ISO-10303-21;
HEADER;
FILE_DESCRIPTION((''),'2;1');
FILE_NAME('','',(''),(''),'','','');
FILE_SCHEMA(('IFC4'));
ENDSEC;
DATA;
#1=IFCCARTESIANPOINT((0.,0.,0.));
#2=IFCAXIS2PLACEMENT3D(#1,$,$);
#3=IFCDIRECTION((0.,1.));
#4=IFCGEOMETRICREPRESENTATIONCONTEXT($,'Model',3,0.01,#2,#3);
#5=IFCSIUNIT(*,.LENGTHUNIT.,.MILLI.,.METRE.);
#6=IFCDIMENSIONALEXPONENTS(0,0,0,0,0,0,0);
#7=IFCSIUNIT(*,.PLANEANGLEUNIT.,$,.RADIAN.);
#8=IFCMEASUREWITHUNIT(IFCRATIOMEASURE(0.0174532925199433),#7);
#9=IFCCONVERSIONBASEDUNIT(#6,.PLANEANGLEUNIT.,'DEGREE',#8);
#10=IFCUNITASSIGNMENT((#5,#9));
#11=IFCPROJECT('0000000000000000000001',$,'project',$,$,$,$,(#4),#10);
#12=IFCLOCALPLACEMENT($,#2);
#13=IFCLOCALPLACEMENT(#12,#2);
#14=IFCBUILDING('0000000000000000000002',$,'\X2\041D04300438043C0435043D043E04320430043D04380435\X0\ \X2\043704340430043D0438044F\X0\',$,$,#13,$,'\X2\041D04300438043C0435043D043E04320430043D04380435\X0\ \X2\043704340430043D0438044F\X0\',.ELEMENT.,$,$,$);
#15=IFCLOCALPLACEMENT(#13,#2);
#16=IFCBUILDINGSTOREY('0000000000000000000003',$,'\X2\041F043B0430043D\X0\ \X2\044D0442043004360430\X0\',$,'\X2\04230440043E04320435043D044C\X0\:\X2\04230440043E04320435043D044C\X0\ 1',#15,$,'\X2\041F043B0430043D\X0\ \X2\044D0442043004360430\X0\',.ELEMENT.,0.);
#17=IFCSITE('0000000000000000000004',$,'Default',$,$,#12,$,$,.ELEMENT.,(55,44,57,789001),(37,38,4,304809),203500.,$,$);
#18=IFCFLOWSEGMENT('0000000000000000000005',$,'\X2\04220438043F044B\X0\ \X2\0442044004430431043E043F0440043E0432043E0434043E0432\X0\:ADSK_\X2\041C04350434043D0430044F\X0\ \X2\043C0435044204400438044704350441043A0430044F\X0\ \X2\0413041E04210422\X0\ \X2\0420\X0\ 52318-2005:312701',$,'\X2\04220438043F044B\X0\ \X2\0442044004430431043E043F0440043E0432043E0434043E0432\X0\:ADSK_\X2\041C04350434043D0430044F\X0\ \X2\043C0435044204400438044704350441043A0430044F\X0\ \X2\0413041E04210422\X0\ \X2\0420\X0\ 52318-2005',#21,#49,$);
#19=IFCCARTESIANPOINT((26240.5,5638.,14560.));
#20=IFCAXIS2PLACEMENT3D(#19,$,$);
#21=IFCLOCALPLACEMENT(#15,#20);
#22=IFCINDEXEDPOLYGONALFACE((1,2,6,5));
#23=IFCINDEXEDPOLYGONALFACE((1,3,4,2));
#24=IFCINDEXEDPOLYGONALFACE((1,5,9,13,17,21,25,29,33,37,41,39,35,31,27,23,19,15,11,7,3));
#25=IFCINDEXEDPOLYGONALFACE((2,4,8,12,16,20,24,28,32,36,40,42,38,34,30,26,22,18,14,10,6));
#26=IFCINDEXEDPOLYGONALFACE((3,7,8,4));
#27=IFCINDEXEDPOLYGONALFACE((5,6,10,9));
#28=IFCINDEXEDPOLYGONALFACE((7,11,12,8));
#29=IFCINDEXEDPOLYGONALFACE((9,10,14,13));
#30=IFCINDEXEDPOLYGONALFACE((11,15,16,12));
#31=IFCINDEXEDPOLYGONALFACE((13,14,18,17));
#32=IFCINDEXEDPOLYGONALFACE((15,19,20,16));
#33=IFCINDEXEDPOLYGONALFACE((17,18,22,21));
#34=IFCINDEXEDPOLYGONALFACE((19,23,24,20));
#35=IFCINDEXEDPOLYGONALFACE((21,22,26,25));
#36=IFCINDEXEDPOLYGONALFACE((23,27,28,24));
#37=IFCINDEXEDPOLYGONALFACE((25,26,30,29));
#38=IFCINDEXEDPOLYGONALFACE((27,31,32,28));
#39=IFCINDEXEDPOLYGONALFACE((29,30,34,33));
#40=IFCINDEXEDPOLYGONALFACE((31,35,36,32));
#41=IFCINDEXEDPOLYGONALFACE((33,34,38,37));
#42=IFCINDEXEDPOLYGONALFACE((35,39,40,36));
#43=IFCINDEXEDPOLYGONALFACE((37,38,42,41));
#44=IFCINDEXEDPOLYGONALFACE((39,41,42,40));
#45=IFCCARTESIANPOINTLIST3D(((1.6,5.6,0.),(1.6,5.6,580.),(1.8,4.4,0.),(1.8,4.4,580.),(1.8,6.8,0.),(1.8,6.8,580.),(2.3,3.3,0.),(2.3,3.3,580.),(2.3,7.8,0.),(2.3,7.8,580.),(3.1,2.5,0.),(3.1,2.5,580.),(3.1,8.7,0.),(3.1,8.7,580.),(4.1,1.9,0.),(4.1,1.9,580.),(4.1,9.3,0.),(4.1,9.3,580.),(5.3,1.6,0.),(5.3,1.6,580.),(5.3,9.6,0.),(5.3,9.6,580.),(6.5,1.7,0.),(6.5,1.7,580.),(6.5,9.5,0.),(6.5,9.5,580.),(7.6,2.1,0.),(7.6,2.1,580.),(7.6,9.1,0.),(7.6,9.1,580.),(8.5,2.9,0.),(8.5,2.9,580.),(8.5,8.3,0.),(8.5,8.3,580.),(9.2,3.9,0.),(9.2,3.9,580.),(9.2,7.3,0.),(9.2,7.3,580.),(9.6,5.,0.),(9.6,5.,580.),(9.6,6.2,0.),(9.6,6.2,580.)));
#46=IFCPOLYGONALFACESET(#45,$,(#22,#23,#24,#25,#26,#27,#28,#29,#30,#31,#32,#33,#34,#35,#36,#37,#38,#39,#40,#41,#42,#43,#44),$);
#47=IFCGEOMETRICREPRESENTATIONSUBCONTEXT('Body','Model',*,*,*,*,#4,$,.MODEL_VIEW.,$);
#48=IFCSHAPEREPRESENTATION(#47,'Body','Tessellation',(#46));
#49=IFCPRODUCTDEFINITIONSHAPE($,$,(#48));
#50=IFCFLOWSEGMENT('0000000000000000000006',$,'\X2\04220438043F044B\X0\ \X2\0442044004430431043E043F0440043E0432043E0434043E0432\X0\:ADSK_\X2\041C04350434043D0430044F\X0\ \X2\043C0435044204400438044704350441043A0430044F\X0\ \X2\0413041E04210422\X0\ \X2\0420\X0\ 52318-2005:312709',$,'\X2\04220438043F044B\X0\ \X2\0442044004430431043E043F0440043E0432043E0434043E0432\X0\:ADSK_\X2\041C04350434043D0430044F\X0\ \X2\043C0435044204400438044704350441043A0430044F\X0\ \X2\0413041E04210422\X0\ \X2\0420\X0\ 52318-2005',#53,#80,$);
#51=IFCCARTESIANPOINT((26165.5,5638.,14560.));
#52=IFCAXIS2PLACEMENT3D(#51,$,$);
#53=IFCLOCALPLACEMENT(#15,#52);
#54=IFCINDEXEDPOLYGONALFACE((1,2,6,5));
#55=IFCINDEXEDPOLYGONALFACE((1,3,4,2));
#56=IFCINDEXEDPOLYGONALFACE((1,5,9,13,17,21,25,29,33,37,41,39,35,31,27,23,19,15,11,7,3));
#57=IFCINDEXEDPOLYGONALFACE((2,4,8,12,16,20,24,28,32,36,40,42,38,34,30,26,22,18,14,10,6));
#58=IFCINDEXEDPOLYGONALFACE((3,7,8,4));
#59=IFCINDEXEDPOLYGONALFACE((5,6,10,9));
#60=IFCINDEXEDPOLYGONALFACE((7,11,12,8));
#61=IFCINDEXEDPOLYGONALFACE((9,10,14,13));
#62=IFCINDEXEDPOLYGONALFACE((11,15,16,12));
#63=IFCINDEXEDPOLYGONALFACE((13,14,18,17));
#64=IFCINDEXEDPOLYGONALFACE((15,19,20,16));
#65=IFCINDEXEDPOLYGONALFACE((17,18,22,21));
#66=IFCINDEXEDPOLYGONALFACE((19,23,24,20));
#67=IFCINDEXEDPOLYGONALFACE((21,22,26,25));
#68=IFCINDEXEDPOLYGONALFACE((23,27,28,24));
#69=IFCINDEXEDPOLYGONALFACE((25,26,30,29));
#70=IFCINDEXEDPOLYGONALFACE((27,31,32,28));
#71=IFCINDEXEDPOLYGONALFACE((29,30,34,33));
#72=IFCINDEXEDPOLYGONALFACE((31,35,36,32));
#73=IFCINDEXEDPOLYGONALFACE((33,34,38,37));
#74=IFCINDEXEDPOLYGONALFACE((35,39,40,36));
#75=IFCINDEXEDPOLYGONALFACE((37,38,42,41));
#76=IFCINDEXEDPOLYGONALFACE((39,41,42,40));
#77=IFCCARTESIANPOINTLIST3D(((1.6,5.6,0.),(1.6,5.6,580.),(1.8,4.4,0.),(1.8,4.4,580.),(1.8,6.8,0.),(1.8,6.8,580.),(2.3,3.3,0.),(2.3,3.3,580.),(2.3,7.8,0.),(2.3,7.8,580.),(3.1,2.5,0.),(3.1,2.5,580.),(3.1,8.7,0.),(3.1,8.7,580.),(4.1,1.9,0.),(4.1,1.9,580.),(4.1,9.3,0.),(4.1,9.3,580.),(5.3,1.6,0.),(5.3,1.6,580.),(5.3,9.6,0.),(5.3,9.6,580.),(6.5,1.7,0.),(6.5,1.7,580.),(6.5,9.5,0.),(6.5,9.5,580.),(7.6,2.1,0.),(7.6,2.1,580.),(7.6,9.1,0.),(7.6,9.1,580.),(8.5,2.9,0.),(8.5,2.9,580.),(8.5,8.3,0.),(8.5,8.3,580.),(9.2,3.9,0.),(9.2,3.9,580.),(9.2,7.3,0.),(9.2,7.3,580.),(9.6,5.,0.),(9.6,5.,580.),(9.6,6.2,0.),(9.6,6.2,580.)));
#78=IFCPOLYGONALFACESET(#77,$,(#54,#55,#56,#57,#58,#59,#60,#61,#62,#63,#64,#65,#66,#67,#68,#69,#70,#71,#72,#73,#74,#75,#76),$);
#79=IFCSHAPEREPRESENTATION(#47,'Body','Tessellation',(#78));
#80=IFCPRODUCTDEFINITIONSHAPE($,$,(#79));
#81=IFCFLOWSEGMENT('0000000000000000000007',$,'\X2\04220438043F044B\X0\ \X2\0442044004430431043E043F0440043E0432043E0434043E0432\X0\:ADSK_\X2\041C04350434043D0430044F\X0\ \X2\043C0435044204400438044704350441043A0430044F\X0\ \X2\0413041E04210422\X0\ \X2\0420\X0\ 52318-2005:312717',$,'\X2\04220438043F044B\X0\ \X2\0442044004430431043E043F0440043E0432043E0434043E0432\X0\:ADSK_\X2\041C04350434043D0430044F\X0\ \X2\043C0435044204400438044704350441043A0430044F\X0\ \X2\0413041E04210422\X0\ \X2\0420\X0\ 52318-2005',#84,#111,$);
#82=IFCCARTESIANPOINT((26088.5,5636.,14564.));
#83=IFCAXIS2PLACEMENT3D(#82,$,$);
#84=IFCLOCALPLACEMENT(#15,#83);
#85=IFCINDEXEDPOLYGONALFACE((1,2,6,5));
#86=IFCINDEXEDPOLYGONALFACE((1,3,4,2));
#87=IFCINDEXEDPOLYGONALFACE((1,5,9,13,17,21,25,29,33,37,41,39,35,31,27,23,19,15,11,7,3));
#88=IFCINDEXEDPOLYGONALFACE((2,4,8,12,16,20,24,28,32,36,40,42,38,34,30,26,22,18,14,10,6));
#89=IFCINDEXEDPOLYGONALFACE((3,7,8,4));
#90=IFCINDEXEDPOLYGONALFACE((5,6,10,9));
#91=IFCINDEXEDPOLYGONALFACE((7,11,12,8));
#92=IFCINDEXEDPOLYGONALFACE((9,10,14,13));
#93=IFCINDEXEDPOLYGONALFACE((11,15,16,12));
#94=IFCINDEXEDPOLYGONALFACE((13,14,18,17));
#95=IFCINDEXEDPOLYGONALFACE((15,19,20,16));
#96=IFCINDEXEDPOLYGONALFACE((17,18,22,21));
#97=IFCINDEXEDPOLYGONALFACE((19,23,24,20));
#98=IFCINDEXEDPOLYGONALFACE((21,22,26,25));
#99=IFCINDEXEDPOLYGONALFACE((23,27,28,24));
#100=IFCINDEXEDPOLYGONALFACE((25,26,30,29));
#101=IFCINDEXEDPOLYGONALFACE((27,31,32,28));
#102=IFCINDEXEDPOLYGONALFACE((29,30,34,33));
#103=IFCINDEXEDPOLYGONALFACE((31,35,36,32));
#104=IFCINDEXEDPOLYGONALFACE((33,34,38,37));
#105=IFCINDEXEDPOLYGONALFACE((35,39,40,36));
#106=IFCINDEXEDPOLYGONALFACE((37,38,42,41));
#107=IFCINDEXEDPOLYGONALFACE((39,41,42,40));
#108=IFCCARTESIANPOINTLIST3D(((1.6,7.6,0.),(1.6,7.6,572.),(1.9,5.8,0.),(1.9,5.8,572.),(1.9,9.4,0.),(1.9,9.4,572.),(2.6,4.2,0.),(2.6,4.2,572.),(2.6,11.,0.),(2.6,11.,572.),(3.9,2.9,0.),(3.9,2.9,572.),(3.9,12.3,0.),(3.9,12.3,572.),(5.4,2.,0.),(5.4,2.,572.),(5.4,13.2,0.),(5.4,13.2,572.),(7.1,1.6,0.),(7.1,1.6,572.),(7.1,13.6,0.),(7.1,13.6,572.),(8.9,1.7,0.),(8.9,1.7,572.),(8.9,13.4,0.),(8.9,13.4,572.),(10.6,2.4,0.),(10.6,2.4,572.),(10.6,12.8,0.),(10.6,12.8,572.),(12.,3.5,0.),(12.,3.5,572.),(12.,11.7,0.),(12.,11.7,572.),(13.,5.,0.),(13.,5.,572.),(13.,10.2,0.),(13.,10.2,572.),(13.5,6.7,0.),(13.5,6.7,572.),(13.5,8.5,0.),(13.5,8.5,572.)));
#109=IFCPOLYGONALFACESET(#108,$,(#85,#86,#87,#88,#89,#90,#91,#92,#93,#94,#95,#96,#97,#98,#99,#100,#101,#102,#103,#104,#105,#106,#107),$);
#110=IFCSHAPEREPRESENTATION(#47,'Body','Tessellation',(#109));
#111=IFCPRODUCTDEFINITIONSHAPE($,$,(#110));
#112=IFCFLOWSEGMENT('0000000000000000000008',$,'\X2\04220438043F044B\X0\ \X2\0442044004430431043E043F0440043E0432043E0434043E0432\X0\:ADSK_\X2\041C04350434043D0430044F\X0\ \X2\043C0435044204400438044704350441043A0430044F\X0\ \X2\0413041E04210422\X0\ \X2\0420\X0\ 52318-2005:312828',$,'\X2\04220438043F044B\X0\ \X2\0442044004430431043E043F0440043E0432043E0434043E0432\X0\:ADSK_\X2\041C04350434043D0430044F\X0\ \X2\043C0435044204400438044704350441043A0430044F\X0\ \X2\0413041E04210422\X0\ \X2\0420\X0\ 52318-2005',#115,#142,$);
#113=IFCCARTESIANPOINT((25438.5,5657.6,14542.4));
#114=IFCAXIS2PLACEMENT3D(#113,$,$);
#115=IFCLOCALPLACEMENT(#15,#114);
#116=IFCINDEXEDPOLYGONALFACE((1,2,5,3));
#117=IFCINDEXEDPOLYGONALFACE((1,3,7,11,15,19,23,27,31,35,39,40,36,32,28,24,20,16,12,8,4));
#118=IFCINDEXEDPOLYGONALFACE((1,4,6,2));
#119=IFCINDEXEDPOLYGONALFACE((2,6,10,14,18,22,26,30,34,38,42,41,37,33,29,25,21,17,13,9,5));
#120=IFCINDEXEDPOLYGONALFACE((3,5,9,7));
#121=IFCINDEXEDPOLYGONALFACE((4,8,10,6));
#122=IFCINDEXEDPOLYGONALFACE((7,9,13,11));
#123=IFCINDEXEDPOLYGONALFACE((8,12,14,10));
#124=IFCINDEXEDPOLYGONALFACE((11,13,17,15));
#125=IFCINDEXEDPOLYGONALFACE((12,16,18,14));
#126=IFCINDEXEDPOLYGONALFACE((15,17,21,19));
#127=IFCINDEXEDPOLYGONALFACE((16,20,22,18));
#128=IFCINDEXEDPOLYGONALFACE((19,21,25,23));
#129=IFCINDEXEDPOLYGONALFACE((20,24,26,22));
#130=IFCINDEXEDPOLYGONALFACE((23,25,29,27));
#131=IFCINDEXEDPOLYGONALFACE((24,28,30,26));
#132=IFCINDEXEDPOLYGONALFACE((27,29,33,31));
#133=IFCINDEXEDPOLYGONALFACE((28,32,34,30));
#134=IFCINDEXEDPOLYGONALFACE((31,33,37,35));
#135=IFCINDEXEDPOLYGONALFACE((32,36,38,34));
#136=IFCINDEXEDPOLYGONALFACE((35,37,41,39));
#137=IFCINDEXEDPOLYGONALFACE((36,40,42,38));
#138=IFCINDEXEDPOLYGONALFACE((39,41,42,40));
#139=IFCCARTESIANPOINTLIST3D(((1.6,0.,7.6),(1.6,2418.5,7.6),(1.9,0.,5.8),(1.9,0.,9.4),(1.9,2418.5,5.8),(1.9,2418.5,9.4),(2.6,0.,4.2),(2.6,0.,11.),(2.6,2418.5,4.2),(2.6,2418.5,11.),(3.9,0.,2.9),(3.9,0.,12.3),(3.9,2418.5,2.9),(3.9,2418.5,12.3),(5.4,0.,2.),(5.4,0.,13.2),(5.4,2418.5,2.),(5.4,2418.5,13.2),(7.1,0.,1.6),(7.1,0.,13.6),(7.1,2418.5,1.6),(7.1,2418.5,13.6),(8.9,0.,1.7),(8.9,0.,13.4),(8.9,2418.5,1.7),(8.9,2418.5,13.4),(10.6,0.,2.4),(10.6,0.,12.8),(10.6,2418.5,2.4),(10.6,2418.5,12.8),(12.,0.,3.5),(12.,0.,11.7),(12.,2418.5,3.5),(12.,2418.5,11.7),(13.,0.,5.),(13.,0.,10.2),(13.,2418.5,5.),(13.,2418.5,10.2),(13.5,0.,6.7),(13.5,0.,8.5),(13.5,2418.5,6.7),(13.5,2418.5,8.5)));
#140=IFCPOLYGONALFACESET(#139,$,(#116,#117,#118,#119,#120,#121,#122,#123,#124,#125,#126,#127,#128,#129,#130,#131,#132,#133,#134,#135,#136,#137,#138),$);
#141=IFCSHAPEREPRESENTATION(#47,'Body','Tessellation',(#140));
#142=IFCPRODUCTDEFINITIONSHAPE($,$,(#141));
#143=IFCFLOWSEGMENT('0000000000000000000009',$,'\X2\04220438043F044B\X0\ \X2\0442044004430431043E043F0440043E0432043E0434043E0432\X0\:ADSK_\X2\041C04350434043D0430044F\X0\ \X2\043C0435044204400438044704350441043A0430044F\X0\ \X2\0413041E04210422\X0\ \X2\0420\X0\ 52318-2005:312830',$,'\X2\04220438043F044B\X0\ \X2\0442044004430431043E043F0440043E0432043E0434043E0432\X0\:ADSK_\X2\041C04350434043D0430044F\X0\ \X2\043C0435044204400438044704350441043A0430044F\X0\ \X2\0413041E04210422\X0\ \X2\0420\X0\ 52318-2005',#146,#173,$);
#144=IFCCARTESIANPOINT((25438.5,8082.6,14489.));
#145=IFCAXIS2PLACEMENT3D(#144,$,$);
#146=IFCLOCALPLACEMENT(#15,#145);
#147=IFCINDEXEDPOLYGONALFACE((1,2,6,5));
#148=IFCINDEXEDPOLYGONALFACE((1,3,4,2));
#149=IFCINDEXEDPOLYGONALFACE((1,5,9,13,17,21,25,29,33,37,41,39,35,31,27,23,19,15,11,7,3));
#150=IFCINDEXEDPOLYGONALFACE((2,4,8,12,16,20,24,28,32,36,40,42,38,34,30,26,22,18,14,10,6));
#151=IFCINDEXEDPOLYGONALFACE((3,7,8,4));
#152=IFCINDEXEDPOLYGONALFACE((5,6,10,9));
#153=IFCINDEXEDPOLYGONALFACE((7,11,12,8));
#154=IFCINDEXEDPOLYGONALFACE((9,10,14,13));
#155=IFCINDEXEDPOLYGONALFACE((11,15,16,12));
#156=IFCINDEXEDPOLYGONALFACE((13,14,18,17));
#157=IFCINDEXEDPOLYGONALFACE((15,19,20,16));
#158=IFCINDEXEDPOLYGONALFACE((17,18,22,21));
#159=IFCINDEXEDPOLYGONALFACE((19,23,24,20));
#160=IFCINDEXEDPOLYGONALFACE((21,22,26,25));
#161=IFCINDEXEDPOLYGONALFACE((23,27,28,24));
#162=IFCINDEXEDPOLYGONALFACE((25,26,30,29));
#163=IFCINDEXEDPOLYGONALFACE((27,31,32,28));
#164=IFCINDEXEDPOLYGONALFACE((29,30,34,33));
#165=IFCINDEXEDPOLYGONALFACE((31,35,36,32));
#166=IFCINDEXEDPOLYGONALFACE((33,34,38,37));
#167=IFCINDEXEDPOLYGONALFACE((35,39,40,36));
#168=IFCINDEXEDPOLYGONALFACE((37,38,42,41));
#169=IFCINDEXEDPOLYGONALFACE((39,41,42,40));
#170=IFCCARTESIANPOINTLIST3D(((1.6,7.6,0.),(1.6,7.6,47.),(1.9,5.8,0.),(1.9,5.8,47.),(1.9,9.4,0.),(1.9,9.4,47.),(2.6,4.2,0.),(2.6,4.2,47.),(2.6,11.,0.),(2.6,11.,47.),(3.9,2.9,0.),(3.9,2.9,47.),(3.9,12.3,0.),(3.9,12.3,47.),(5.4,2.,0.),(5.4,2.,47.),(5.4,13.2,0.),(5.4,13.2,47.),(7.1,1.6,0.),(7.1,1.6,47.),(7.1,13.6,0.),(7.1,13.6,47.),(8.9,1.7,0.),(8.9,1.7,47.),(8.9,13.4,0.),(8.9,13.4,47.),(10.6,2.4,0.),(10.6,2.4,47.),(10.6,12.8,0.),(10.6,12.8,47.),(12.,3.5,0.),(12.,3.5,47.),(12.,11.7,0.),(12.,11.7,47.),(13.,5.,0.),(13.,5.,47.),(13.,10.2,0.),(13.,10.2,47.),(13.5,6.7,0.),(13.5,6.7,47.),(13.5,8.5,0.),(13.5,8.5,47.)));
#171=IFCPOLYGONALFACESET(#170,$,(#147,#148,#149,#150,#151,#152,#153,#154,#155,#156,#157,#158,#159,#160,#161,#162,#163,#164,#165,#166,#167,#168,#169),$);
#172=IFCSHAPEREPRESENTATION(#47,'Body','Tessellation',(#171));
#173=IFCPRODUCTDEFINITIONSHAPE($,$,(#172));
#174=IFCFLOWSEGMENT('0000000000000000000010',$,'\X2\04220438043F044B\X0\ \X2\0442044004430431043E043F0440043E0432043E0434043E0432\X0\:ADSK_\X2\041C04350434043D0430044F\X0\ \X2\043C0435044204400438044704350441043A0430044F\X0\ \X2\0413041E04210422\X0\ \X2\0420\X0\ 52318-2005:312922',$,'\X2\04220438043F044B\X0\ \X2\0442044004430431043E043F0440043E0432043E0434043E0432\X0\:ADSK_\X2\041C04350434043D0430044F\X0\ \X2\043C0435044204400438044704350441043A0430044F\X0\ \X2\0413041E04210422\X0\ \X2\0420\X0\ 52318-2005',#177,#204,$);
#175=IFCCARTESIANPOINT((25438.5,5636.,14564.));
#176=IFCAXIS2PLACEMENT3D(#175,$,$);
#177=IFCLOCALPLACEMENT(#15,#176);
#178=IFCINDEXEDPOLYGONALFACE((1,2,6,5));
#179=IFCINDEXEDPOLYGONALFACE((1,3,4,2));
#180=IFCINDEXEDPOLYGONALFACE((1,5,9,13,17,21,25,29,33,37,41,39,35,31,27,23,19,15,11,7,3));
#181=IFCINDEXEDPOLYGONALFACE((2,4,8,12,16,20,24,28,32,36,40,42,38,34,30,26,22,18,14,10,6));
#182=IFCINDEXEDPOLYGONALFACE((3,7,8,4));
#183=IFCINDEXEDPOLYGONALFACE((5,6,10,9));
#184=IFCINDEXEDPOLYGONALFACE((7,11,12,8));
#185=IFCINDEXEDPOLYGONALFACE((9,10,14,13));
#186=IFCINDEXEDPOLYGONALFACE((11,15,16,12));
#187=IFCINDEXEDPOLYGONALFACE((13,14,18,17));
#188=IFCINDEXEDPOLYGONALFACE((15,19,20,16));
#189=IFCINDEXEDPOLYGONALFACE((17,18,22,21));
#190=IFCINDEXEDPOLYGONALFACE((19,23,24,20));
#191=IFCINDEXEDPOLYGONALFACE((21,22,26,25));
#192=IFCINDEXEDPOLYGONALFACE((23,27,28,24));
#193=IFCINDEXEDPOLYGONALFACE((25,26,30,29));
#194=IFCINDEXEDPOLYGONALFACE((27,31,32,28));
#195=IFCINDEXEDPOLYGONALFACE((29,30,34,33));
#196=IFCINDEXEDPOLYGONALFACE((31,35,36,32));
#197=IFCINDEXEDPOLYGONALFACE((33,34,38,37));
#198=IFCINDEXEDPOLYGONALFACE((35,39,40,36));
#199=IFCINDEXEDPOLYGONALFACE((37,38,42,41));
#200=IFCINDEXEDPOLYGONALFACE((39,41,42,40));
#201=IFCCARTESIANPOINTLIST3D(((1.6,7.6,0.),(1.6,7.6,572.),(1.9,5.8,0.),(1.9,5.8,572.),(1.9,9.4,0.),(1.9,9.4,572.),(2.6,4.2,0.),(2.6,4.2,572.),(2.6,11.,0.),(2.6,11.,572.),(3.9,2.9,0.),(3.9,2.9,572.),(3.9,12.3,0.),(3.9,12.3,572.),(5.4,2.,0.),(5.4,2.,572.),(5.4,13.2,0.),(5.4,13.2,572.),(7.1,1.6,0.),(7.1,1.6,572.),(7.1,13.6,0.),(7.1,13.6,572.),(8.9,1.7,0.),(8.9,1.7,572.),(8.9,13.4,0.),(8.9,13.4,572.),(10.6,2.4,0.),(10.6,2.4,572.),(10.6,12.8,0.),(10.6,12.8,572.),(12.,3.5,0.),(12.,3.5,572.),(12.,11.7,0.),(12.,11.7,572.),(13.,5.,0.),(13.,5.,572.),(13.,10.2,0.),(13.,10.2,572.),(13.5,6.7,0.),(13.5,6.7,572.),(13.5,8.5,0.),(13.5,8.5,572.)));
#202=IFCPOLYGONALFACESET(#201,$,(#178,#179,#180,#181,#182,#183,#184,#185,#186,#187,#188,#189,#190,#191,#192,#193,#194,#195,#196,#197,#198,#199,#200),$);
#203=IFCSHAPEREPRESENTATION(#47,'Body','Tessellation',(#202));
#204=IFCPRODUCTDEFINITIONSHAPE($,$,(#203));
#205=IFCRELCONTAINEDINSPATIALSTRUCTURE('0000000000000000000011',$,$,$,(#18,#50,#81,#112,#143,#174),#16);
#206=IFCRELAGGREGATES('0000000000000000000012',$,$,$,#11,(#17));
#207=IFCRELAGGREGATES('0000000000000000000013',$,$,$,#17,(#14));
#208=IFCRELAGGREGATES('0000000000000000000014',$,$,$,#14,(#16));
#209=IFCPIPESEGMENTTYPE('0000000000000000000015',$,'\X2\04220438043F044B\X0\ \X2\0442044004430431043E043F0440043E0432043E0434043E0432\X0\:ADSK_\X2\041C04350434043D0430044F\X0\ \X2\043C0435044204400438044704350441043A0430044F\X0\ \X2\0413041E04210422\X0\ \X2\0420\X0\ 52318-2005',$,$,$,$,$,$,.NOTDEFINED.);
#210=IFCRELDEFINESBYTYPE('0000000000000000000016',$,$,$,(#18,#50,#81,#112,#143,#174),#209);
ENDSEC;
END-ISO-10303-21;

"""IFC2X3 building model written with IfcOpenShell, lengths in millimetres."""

from ifc_helpers import new_model, entity, si_unit, converted_unit, direction, frame, frame_2d, origin, origin_2d_with_axis, place, context, subcontext, project, spatial, circle, extrude, type_object, element, save


model = new_model("IFC2X3")

# Units and contexts
model_context = context("Model", 3, precision=0.01, world=origin(), true_north=direction((0.0, 1.0)))
body_context = subcontext(model_context, "Body", "Model", "MODEL_VIEW")
ifc_project = project(units=[si_unit("LENGTHUNIT", "METRE", prefix="MILLI"), converted_unit("PLANEANGLEUNIT", "DEGREE", entity("IfcRatioMeasure", 0.0174532925199433), si_unit("PLANEANGLEUNIT", "RADIAN"), dimensions=[0, 0, 0, 0, 0, 0, 0])], contexts=[model_context])

# Site, building, storey
site_placement = place(None, frame((0.0, 0.0, 0.0)))
site = spatial("IfcSite", under=ifc_project, at=site_placement, Name="Default", CompositionType="ELEMENT", RefLatitude=(55, 44, 57, 789001), RefLongitude=(37, 38, 4, 304809), RefElevation=203500.0)
building_placement = place(site_placement, origin())
building = spatial("IfcBuilding", under=site, at=building_placement, Name="Наименование здания", LongName="Наименование здания", CompositionType="ELEMENT")
storey_placement = place(building_placement, origin())
storey = spatial("IfcBuildingStorey", under=building, at=storey_placement, Name="План этажа", ObjectType="Уровень:Уровень 1", LongName="План этажа", CompositionType="ELEMENT", Elevation=0.0)

# Flow segments
pipe_segment_type = type_object("IfcPipeSegmentType", Name="Типы трубопроводов:ADSK_Медная метрическая ГОСТ Р 52318-2005", PredefinedType="NOTDEFINED")
flow_segment_1_placement = place(storey_placement, frame((26240.5, 5638.0, 14560.0)))
element("IfcFlowSegment", 1, at=flow_segment_1_placement, inside=storey, type_object=pipe_segment_type, Name="Типы трубопроводов:ADSK_Медная метрическая ГОСТ Р 52318-2005:312701", ObjectType="Типы трубопроводов:ADSK_Медная метрическая ГОСТ Р 52318-2005", context=body_context, shape_type="SweptSolid", body=[
    extrude(circle(Radius=4.0, at=origin_2d_with_axis()), frame((5.6, 5.6, 0.0), z_axis=(0.0, 0.0, 1.0), x_axis=(-1.0, 0.0, 0.0)), (0.0, 0.0, 1.0), 580.0),
])
flow_segment_2_placement = place(storey_placement, frame((26165.5, 5638.0, 14560.0)))
element("IfcFlowSegment", 2, at=flow_segment_2_placement, inside=storey, type_object=pipe_segment_type, Name="Типы трубопроводов:ADSK_Медная метрическая ГОСТ Р 52318-2005:312709", ObjectType="Типы трубопроводов:ADSK_Медная метрическая ГОСТ Р 52318-2005", context=body_context, shape_type="SweptSolid", body=[
    extrude(circle(Radius=4.0, at=origin_2d_with_axis()), frame((5.6, 5.6, 0.0), z_axis=(0.0, 0.0, 1.0), x_axis=(-1.0, 0.0, 0.0)), (0.0, 0.0, 1.0), 580.0),
])
flow_segment_3_placement = place(storey_placement, frame((26088.5, 5636.0, 14564.0)))
element("IfcFlowSegment", 3, at=flow_segment_3_placement, inside=storey, type_object=pipe_segment_type, Name="Типы трубопроводов:ADSK_Медная метрическая ГОСТ Р 52318-2005:312717", ObjectType="Типы трубопроводов:ADSK_Медная метрическая ГОСТ Р 52318-2005", context=body_context, shape_type="SweptSolid", body=[
    extrude(circle(Radius=6.0, at=origin_2d_with_axis()), frame((7.6, 7.6, 0.0), z_axis=(0.0, 0.0, 1.0), x_axis=(-1.0, 0.0, 0.0)), (0.0, 0.0, 1.0), 572.0),
])
flow_segment_4_placement = place(storey_placement, frame((25438.5, 5657.6, 14542.4)))
element("IfcFlowSegment", 4, at=flow_segment_4_placement, inside=storey, type_object=pipe_segment_type, Name="Типы трубопроводов:ADSK_Медная метрическая ГОСТ Р 52318-2005:312828", ObjectType="Типы трубопроводов:ADSK_Медная метрическая ГОСТ Р 52318-2005", context=body_context, shape_type="SweptSolid", body=[
    extrude(circle(Radius=6.0, at=frame_2d((0.0, 0.0), x_axis=(1.0, 0.0))), frame((7.6, 0.0, 7.6), z_axis=(0.0, 1.0, 0.0), x_axis=(-1.0, 0.0, 0.0)), (0.0, 0.0, 1.0), 2418.5),
])
flow_segment_5_placement = place(storey_placement, frame((25438.5, 8082.6, 14489.0)))
element("IfcFlowSegment", 5, at=flow_segment_5_placement, inside=storey, type_object=pipe_segment_type, Name="Типы трубопроводов:ADSK_Медная метрическая ГОСТ Р 52318-2005:312830", ObjectType="Типы трубопроводов:ADSK_Медная метрическая ГОСТ Р 52318-2005", context=body_context, shape_type="SweptSolid", body=[
    extrude(circle(Radius=6.0, at=origin_2d_with_axis()), frame((7.6, 7.6, 0.0), z_axis=(0.0, 0.0, 1.0), x_axis=(-1.0, 0.0, 0.0)), (0.0, 0.0, 1.0), 47.0),
])
flow_segment_6_placement = place(storey_placement, frame((25438.5, 5636.0, 14564.0)))
element("IfcFlowSegment", 6, at=flow_segment_6_placement, inside=storey, type_object=pipe_segment_type, Name="Типы трубопроводов:ADSK_Медная метрическая ГОСТ Р 52318-2005:312922", ObjectType="Типы трубопроводов:ADSK_Медная метрическая ГОСТ Р 52318-2005", context=body_context, shape_type="SweptSolid", body=[
    extrude(circle(Radius=6.0, at=origin_2d_with_axis()), frame((7.6, 7.6, 0.0), z_axis=(0.0, 0.0, 1.0), x_axis=(-1.0, 0.0, 0.0)), (0.0, 0.0, 1.0), 572.0),
])

save(model, "model.ifc")
